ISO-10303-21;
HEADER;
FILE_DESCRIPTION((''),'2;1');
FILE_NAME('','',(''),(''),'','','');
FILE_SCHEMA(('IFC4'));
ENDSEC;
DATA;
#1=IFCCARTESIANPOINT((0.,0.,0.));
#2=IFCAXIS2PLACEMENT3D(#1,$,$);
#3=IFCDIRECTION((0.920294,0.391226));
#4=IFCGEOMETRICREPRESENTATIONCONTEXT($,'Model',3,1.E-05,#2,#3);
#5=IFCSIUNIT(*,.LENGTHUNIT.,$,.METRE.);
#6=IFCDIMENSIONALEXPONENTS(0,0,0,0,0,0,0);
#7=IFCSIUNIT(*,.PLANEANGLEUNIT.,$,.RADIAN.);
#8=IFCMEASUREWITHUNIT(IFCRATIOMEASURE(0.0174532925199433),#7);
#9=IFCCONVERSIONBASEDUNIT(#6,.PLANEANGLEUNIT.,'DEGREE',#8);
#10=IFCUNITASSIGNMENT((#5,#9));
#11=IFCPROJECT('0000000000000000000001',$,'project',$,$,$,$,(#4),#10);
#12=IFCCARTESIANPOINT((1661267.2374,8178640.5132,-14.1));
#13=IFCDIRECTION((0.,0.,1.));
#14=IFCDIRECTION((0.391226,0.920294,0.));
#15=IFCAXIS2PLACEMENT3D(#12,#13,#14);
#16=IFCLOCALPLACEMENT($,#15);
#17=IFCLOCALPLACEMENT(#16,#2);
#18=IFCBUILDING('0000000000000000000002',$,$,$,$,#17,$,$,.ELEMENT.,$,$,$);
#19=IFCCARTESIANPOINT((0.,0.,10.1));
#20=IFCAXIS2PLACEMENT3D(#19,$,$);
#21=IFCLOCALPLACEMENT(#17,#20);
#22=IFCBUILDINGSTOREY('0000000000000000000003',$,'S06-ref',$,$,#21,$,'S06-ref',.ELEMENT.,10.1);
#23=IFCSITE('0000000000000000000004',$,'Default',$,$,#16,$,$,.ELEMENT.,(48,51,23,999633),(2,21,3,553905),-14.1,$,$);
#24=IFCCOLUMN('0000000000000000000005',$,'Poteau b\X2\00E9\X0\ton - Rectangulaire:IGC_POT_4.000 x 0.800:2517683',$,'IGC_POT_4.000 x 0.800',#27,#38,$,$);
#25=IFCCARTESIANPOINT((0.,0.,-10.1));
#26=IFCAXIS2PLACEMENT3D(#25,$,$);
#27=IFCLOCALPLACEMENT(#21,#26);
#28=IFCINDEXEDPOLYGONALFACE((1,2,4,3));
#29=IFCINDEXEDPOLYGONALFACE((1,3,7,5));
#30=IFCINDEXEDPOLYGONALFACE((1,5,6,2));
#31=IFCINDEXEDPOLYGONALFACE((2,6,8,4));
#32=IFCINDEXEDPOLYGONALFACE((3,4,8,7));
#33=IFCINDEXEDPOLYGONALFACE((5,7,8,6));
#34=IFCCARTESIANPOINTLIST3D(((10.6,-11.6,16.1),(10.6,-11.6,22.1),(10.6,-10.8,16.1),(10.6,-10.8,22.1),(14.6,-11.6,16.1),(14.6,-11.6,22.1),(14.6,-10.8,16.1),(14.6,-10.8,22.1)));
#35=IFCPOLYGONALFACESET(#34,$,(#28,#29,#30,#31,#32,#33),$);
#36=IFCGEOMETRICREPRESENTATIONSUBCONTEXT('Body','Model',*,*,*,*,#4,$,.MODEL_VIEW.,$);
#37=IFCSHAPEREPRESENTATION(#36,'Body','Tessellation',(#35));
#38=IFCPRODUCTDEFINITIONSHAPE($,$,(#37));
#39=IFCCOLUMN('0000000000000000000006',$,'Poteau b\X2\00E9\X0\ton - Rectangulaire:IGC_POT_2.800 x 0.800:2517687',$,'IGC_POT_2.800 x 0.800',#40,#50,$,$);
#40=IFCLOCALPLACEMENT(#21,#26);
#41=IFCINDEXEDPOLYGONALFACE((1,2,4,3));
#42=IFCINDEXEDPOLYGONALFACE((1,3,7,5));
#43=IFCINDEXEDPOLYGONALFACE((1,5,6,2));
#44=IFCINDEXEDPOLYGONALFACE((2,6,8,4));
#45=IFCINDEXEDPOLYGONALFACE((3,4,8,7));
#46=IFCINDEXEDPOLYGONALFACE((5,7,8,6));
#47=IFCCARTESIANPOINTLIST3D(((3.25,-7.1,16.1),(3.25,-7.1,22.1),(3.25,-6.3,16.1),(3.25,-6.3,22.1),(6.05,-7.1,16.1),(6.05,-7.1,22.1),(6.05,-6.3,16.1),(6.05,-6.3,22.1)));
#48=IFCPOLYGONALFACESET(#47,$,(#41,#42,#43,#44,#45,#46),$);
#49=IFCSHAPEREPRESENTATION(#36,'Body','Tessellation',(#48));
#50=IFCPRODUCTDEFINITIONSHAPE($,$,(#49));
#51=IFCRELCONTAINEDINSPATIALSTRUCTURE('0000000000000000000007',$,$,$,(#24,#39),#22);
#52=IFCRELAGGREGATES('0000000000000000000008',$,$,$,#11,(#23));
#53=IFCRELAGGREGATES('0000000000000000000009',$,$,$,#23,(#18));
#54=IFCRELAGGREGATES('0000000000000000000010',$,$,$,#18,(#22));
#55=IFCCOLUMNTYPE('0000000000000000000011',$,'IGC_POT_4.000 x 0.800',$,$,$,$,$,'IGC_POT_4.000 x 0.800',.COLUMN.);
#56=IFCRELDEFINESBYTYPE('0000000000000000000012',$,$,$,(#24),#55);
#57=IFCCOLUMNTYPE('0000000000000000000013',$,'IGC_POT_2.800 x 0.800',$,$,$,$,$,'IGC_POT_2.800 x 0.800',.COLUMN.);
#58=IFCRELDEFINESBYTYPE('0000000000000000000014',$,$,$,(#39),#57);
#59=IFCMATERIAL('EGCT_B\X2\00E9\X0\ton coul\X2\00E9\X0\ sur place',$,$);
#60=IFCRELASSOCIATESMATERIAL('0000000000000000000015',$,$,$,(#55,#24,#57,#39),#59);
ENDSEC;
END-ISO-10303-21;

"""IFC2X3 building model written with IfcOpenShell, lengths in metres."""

from ifc_helpers import new_model, entity, si_unit, converted_unit, direction, frame, origin, origin_2d_with_axis, place, context, subcontext, project, spatial, rectangle, extrude, source, transform, mapped, material, type_object, type_shapes, element, save


model = new_model("IFC2X3")

# Units and contexts
model_context = context("Model", 3, precision=1e-05, world=origin(), true_north=direction((0.920294, 0.391226)))
body_context = subcontext(model_context, "Body", "Model", "MODEL_VIEW")
ifc_project = project(units=[si_unit("LENGTHUNIT", "METRE"), converted_unit("PLANEANGLEUNIT", "DEGREE", entity("IfcRatioMeasure", 0.0174532925199433), si_unit("PLANEANGLEUNIT", "RADIAN"), dimensions=[0, 0, 0, 0, 0, 0, 0])], contexts=[model_context])

# Site, building, storey
site_placement = place(None, frame((1661267.2374, 8178640.5132, -14.1), z_axis=(0.0, 0.0, 1.0), x_axis=(0.391226, 0.920294, 0.0)))
site = spatial("IfcSite", under=ifc_project, at=site_placement, Name="Default", CompositionType="ELEMENT", RefLatitude=(48, 51, 23, 999633), RefLongitude=(2, 21, 3, 553905), RefElevation=-14.1)
building_placement = place(site_placement, origin())
building = spatial("IfcBuilding", under=site, at=building_placement, CompositionType="ELEMENT")
storey_placement = place(building_placement, frame((0.0, 0.0, 10.1)))
storey = spatial("IfcBuildingStorey", under=building, at=storey_placement, Name="S06-ref", LongName="S06-ref", CompositionType="ELEMENT", Elevation=10.1)

# Columns
ifc_material_1 = material(Name="EGCT_Béton coulé sur place")
column_type_1 = type_object("IfcColumnType", Name="IGC_POT_4.000 x 0.800", ElementType="IGC_POT_4.000 x 0.800", PredefinedType="COLUMN", material=ifc_material_1)
shared_shape_1 = source(origin(), body_context, "Body", "SweptSolid", [
    extrude(rectangle(XDim=0.8, YDim=4.0, at=origin_2d_with_axis()), frame((12.6, -11.2, 16.1), z_axis=(0.0, 0.0, 1.0), x_axis=(0.0, -1.0, 0.0)), (0.0, 0.0, 1.0), 6.0),
])
type_shapes(column_type_1, [shared_shape_1])
column_1_placement = place(storey_placement, frame((0.0, 0.0, -10.1)))
element("IfcColumn", 1, at=column_1_placement, inside=storey, type_object=column_type_1, material=ifc_material_1, Name="Poteau béton - Rectangulaire:IGC_POT_4.000 x 0.800:2517683", ObjectType="IGC_POT_4.000 x 0.800", context=body_context, shape_type="MappedRepresentation", body=[
    mapped(shared_shape_1, transform((0.0, 0.0, 0.0), scale=1.0)),
])
column_type_2 = type_object("IfcColumnType", Name="IGC_POT_2.800 x 0.800", ElementType="IGC_POT_2.800 x 0.800", PredefinedType="COLUMN", material=ifc_material_1)
shared_shape_2 = source(origin(), body_context, "Body", "SweptSolid", [
    extrude(rectangle(XDim=0.8, YDim=2.8, at=origin_2d_with_axis()), frame((4.65, -6.7, 16.1), z_axis=(0.0, 0.0, 1.0), x_axis=(0.0, -1.0, 0.0)), (0.0, 0.0, 1.0), 6.0),
])
type_shapes(column_type_2, [shared_shape_2])
column_2_placement = place(storey_placement, frame((0.0, 0.0, -10.1)))
element("IfcColumn", 2, at=column_2_placement, inside=storey, type_object=column_type_2, material=ifc_material_1, Name="Poteau béton - Rectangulaire:IGC_POT_2.800 x 0.800:2517687", ObjectType="IGC_POT_2.800 x 0.800", context=body_context, shape_type="MappedRepresentation", body=[
    mapped(shared_shape_2, transform((0.0, 0.0, 0.0), scale=1.0)),
])

save(model, "model.ifc")
